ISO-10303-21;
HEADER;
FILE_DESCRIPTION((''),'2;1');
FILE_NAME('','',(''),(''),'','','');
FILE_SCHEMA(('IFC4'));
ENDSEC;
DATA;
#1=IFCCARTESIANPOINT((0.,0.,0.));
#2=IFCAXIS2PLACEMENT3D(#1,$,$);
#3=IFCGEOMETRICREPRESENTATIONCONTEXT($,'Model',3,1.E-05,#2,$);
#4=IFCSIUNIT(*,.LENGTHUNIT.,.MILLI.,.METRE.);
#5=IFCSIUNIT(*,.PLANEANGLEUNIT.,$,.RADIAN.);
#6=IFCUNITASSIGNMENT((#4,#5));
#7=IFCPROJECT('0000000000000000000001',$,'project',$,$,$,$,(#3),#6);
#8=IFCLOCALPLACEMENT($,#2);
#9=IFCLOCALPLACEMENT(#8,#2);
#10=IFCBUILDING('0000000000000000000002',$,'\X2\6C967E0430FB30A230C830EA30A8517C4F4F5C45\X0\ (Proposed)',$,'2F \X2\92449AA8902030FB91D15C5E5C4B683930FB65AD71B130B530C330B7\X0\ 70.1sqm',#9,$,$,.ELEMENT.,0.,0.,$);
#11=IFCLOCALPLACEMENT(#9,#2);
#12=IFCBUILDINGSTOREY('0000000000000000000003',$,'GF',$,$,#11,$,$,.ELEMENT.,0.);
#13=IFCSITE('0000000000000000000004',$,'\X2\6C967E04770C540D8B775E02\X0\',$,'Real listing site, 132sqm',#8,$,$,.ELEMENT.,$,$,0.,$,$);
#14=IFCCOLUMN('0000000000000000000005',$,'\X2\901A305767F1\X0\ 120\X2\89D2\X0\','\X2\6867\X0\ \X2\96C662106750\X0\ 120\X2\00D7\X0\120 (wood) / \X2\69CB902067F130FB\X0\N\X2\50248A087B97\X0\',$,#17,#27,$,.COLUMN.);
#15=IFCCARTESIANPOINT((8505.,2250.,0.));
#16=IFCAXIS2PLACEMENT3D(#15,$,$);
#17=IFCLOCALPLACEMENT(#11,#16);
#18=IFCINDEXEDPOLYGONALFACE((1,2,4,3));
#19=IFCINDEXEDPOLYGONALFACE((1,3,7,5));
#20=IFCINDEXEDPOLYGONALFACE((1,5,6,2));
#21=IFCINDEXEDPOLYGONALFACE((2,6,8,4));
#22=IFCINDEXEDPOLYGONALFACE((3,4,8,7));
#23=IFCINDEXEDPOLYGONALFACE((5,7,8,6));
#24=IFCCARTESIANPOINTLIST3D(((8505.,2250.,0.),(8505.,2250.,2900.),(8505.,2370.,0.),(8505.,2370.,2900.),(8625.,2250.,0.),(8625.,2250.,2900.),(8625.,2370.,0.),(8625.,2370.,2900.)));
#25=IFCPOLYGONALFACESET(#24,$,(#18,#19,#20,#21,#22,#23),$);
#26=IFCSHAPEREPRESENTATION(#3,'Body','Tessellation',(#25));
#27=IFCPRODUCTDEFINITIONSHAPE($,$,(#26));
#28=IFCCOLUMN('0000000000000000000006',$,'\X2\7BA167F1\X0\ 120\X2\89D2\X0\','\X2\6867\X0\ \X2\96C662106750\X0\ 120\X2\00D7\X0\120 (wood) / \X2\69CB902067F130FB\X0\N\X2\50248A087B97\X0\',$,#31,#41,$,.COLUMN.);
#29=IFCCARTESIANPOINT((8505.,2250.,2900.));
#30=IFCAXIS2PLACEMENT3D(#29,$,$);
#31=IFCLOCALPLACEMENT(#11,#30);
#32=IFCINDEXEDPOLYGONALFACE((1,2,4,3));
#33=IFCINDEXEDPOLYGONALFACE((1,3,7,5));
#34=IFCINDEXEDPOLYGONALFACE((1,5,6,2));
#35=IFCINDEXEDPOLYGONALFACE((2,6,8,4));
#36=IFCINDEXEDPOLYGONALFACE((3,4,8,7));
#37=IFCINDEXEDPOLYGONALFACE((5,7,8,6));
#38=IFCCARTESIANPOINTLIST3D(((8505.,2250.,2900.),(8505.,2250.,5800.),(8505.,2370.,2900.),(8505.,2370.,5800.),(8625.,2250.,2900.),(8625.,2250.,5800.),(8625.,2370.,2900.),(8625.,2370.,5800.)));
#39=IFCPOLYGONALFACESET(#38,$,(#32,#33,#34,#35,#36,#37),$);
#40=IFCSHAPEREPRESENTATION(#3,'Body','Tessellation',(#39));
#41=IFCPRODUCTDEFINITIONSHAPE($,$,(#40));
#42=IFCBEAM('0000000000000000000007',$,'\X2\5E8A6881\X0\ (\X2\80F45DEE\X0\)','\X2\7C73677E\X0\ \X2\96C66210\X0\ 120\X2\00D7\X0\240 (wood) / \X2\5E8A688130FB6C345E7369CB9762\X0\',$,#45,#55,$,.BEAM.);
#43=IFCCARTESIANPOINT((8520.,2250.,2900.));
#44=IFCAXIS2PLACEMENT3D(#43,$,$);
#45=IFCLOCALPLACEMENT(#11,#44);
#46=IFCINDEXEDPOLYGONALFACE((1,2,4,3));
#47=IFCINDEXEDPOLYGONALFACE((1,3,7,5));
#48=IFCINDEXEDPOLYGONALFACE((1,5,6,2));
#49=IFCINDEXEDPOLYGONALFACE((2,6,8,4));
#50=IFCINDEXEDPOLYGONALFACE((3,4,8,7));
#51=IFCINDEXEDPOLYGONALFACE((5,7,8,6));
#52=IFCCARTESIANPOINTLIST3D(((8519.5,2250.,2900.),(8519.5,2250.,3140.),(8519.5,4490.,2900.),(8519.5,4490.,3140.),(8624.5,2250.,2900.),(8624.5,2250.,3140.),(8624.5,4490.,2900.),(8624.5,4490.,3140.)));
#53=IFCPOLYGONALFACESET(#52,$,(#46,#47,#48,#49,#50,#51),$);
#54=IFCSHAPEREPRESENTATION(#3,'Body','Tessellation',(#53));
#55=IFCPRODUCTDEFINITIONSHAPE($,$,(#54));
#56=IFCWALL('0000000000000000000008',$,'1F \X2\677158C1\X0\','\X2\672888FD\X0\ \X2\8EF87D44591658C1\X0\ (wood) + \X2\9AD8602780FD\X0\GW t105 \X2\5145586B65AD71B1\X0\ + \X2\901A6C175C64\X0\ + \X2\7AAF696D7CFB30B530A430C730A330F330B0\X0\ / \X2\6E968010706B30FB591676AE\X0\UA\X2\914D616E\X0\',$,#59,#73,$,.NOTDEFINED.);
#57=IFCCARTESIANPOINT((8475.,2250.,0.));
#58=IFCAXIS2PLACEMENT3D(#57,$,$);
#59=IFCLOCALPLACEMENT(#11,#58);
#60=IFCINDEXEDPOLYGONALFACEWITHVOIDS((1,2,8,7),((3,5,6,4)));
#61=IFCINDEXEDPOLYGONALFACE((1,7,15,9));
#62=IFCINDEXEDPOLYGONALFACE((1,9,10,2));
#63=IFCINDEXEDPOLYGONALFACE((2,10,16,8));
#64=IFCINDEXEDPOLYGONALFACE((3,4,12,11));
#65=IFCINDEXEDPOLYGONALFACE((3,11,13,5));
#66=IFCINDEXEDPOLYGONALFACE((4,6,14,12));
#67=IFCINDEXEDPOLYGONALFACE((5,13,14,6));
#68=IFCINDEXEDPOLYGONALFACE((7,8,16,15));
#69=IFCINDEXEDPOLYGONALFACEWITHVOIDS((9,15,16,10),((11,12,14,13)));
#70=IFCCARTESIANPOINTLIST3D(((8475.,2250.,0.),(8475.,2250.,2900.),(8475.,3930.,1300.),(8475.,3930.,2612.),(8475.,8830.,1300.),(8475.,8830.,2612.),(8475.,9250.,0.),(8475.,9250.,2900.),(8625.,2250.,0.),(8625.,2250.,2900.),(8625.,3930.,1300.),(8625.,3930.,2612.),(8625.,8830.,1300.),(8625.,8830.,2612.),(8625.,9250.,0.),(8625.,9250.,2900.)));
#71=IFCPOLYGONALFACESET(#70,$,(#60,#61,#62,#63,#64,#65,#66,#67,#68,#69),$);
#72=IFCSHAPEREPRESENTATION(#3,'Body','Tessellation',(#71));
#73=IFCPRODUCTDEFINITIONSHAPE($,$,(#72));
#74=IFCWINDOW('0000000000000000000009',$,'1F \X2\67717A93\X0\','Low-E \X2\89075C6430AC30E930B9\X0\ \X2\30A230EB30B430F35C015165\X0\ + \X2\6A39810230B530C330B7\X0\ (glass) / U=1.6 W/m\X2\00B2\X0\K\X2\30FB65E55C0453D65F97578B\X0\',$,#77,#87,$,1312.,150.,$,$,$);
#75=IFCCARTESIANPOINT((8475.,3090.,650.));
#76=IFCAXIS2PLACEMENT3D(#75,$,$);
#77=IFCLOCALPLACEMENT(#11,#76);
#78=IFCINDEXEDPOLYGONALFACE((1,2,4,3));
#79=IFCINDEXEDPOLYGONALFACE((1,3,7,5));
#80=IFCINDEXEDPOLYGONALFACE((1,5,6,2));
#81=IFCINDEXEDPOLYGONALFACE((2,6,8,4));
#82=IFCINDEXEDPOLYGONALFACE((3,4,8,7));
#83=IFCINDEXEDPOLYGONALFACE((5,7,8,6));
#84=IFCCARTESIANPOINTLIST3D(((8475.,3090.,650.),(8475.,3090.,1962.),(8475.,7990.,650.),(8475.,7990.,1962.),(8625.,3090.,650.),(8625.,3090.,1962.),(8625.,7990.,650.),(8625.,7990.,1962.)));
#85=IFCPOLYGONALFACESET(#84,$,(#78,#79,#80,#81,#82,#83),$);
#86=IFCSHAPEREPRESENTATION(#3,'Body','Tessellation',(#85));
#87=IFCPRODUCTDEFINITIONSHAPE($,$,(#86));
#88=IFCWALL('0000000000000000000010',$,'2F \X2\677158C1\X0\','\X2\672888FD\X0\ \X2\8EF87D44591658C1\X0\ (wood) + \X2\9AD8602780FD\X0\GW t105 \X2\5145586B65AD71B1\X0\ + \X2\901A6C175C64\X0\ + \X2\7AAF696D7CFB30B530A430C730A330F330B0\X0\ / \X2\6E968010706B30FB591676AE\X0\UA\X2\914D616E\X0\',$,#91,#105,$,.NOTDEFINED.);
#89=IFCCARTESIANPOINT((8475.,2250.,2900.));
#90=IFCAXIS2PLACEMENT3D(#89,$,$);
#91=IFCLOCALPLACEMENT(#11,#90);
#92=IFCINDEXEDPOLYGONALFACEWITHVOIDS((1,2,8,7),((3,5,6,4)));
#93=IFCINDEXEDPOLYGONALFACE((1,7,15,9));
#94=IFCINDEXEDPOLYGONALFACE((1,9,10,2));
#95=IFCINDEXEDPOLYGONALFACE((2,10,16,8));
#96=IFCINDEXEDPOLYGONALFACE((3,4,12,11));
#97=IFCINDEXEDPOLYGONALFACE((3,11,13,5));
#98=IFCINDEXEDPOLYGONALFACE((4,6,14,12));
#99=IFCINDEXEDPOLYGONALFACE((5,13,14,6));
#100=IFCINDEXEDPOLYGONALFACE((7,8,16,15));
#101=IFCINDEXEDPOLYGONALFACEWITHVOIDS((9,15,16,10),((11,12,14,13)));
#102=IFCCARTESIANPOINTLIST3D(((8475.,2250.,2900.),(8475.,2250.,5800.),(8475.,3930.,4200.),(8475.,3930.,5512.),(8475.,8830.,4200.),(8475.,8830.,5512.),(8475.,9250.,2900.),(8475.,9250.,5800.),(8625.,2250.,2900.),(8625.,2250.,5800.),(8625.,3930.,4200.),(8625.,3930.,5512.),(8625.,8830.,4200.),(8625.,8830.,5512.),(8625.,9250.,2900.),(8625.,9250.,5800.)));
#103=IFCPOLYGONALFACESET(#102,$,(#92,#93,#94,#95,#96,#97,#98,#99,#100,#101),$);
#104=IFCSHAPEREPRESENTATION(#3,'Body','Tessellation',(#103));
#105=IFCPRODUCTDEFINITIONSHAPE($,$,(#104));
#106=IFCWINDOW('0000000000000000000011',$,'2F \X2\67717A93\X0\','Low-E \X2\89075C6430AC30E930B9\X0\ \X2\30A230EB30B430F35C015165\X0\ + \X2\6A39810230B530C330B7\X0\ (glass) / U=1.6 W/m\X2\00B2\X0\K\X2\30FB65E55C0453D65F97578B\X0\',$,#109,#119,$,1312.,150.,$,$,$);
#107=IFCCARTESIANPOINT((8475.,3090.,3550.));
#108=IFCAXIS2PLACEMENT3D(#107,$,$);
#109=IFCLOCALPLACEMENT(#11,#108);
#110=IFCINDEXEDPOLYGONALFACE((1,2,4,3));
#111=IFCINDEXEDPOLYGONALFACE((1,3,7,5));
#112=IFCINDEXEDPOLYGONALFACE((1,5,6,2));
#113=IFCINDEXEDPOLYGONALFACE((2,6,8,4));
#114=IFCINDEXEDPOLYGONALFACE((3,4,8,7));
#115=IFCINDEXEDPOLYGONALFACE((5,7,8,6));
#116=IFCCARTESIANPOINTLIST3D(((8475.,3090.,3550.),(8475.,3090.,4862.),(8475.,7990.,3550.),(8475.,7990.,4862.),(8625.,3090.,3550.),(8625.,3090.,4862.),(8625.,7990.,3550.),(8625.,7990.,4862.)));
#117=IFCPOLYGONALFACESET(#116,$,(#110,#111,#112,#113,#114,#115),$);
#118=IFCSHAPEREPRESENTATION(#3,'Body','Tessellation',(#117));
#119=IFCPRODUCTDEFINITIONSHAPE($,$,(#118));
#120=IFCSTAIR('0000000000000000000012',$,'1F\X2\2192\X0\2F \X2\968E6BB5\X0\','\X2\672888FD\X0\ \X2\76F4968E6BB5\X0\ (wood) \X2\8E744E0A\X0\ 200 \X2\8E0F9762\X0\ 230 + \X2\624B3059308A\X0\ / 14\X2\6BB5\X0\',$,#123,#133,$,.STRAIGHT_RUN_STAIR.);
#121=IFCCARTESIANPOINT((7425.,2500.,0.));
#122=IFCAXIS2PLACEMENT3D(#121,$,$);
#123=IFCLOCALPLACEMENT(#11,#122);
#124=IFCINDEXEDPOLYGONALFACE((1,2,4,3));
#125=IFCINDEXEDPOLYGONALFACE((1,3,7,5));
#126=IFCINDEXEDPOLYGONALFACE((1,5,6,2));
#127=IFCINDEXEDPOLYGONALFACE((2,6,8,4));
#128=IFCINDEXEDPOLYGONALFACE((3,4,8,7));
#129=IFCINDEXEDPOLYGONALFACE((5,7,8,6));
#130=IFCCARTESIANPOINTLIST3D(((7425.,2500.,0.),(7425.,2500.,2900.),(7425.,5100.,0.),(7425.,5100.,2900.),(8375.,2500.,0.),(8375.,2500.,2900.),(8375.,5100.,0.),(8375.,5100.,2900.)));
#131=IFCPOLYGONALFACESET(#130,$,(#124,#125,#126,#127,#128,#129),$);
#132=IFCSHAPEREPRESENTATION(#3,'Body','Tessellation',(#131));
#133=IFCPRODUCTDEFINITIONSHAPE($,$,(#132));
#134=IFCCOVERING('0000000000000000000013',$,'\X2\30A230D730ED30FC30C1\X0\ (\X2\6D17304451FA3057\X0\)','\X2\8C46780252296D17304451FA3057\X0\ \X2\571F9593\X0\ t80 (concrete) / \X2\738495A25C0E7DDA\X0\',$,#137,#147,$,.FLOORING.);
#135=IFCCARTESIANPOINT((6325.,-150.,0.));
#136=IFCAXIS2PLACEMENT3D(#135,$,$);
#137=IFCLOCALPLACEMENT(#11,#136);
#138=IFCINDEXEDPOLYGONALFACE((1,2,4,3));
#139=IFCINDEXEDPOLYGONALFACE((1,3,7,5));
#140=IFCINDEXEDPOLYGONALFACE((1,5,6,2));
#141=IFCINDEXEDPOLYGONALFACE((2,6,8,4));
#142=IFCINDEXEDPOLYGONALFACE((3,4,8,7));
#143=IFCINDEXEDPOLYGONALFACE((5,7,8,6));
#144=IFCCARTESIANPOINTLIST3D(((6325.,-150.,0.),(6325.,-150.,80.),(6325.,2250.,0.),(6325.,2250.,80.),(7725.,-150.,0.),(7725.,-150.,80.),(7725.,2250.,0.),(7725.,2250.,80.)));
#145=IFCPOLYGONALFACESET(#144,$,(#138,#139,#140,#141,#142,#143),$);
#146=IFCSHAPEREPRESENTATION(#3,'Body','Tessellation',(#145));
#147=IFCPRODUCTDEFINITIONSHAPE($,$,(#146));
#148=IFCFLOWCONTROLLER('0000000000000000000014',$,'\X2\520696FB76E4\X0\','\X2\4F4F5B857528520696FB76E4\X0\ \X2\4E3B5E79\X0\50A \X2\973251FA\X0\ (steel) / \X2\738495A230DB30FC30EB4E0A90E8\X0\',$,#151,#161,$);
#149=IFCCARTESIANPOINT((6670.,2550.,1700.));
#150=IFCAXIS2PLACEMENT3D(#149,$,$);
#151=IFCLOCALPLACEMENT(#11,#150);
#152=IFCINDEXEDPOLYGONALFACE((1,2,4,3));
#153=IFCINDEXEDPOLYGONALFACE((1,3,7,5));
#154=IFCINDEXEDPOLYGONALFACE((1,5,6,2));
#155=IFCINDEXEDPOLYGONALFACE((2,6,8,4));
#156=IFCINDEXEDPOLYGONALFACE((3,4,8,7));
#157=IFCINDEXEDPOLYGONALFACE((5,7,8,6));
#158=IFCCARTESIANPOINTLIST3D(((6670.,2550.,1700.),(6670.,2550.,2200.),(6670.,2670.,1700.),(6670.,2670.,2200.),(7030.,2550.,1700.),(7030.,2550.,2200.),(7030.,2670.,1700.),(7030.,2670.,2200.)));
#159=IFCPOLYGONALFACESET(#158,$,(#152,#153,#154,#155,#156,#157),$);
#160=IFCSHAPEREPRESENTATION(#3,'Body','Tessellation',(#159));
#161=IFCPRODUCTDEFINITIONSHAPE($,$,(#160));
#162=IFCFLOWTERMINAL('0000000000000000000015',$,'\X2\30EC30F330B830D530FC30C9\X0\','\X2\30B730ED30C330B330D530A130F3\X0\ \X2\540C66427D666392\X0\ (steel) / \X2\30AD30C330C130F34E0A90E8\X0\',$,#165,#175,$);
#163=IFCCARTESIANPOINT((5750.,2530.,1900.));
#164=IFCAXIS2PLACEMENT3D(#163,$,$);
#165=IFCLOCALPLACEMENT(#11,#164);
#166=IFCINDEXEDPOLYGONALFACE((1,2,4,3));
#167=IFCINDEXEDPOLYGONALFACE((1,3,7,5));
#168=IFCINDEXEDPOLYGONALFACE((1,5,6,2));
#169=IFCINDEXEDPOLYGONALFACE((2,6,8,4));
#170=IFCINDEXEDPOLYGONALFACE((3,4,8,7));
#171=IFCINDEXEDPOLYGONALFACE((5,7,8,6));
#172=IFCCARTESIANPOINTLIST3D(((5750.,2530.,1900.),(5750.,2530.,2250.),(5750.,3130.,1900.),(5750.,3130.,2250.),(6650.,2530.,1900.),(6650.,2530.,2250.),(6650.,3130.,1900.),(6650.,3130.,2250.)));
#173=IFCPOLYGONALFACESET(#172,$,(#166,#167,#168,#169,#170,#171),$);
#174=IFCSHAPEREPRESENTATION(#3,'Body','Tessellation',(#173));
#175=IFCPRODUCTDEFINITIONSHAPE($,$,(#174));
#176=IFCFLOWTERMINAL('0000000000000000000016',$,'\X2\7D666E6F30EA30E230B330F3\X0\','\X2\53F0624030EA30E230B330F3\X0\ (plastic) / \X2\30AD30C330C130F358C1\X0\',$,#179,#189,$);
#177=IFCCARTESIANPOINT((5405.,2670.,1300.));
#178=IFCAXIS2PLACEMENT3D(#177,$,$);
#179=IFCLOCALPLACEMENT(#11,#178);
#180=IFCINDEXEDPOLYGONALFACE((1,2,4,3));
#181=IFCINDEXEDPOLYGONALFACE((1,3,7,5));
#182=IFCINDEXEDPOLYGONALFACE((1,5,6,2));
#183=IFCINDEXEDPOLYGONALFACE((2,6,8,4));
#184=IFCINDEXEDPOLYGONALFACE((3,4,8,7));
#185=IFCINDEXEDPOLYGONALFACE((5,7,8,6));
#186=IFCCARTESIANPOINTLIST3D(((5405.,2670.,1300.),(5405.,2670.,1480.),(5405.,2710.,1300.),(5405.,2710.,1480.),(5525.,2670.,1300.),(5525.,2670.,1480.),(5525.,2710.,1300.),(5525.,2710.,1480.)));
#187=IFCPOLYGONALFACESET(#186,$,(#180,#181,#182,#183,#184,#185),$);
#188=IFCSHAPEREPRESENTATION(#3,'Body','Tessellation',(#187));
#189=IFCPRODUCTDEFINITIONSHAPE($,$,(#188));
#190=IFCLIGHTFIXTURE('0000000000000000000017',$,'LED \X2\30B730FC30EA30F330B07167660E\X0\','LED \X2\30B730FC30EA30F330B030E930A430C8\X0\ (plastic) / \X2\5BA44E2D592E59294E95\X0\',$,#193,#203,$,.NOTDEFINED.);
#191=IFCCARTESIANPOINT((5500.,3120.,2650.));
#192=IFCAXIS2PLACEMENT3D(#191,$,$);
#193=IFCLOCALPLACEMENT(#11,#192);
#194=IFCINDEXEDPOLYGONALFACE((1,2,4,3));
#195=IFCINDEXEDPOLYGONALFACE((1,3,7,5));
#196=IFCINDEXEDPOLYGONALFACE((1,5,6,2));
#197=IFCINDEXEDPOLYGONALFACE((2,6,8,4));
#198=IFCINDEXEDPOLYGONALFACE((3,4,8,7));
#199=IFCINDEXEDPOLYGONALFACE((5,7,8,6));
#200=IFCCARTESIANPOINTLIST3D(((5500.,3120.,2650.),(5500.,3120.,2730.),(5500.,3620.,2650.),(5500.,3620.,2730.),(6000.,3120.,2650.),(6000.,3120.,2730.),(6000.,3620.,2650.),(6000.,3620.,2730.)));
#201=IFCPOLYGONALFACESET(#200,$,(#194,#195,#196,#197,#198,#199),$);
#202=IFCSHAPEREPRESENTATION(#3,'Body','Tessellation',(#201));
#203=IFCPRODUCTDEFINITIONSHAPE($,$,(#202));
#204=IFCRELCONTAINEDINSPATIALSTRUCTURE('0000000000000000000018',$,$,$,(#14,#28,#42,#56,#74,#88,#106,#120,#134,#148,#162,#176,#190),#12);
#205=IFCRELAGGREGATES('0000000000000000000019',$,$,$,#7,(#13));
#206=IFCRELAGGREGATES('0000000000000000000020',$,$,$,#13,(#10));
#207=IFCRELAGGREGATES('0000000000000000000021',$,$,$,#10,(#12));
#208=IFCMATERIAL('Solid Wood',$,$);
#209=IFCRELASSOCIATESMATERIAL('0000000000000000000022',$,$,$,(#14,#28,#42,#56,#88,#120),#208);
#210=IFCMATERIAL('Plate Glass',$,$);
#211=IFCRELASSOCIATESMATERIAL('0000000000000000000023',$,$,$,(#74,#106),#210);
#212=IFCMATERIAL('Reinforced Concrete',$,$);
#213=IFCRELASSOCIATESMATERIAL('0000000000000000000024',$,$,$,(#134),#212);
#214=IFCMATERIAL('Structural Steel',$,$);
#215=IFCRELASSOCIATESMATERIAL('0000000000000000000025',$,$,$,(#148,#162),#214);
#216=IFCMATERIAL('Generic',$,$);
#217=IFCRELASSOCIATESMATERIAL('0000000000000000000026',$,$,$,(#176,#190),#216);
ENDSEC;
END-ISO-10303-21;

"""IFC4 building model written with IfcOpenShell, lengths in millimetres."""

from ifc_helpers import new_model, si_unit, frame, frame_2d, origin, place, context, project, spatial, rectangle, extrude, material, element, fill, save


model = new_model("IFC4")

# Units and contexts
model_context = context("Model", 3, precision=1e-05, world=origin())
ifc_project = project(units=[si_unit("LENGTHUNIT", "METRE", prefix="MILLI"), si_unit("PLANEANGLEUNIT", "RADIAN")], contexts=[model_context])

# Site, building, storey
site_placement = place(None, origin())
site = spatial("IfcSite", under=ifc_project, at=site_placement, Name="沖縄県名護市", ObjectType="Real listing site, 132sqm", CompositionType="ELEMENT", RefElevation=0.0)
building_placement = place(site_placement, origin())
building = spatial("IfcBuilding", under=site, at=building_placement, Name="沖縄・アトリエ兼住居 (Proposed)", ObjectType="2F 鉄骨造・金属屋根・断熱サッシ 70.1sqm", CompositionType="ELEMENT", ElevationOfRefHeight=0.0, ElevationOfTerrain=0.0)
storey_placement = place(building_placement, origin())
storey = spatial("IfcBuildingStorey", under=building, at=storey_placement, Name="GF", CompositionType="ELEMENT", Elevation=0.0)

# Columns
ifc_material_1 = material(Name="Solid Wood")
column_1_placement = place(storey_placement, frame((8505.0, 2250.0, 0.0)))
element("IfcColumn", 1, at=column_1_placement, inside=storey, material=ifc_material_1, Name="通し柱 120角", Description="桧 集成材 120×120 (wood) / 構造柱・N値計算", PredefinedType="COLUMN", context=model_context, shape_type="SweptSolid", body=[
    extrude(rectangle(XDim=120.0, YDim=120.0, at=frame_2d((60.0, 60.0))), frame((8505.0, 2250.0, 0.0)), (0.0, 0.0, 1.0), 2900.0),
])
column_2_placement = place(storey_placement, frame((8505.0, 2250.0, 2900.0)))
element("IfcColumn", 2, at=column_2_placement, inside=storey, material=ifc_material_1, Name="管柱 120角", Description="桧 集成材 120×120 (wood) / 構造柱・N値計算", PredefinedType="COLUMN", context=model_context, shape_type="SweptSolid", body=[
    extrude(rectangle(XDim=120.0, YDim=120.0, at=frame_2d((60.0, 60.0))), frame((8505.0, 2250.0, 2900.0)), (0.0, 0.0, 1.0), 2900.0),
])

# Beam
beam_1_placement = place(storey_placement, frame((8520.0, 2250.0, 2900.0)))
element("IfcBeam", 3, at=beam_1_placement, inside=storey, material=ifc_material_1, Name="床梁 (胴差)", Description="米松 集成 120×240 (wood) / 床梁・水平構面", PredefinedType="BEAM", context=model_context, shape_type="SweptSolid", body=[
    extrude(rectangle(XDim=105.0, YDim=2240.0, at=frame_2d((52.0, 1120.0))), frame((8520.0, 2250.0, 2900.0)), (0.0, 0.0, 1.0), 240.0),
])

# Wall, opening, window
wall_1_placement = place(storey_placement, frame((8475.0, 2250.0, 0.0)))
wall_1 = element("IfcWall", 4, at=wall_1_placement, inside=storey, material=ifc_material_1, Name="1F 東壁", Description="木製 軸組外壁 (wood) + 高性能GW t105 充填断熱 + 通気層 + 窯業系サイディング / 準耐火・外皮UA配慮", PredefinedType="NOTDEFINED", context=model_context, shape_type="SweptSolid", body=[
    extrude(rectangle(XDim=150.0, YDim=7000.0, at=frame_2d((75.0, 3500.0))), frame((8475.0, 2250.0, 0.0)), (0.0, 0.0, 1.0), 2900.0),
])
opening_1_placement = place(storey_placement, frame((8475.0, 3090.0, 650.0)))
opening_1 = element("IfcOpeningElement", 5, at=opening_1_placement, cuts=wall_1, PredefinedType="NOTDEFINED", context=model_context, shape_type="SweptSolid", body=[
    extrude(rectangle(XDim=150.0, YDim=4900.0, at=frame_2d((75.0, 2450.0))), frame((8475.0, 3090.0, 650.0)), (0.0, 0.0, 1.0), 1312.0),
])
ifc_material_2 = material(Name="Plate Glass")
window_1_placement = place(storey_placement, frame((8475.0, 3090.0, 650.0)))
window_1 = element("IfcWindow", 6, at=window_1_placement, inside=storey, material=ifc_material_2, Name="1F 東窓", Description="Low-E 複層ガラス アルゴン封入 + 樹脂サッシ (glass) / U=1.6 W/m²K・日射取得型", OverallHeight=1312.0, OverallWidth=150.0, context=model_context, shape_type="SweptSolid", body=[
    extrude(rectangle(XDim=150.0, YDim=4900.0, at=frame_2d((75.0, 2450.0))), frame((8475.0, 3090.0, 650.0)), (0.0, 0.0, 1.0), 1312.0),
])
fill(opening_1, window_1)

# Wall, opening, window
wall_2_placement = place(storey_placement, frame((8475.0, 2250.0, 2900.0)))
wall_2 = element("IfcWall", 7, at=wall_2_placement, inside=storey, material=ifc_material_1, Name="2F 東壁", Description="木製 軸組外壁 (wood) + 高性能GW t105 充填断熱 + 通気層 + 窯業系サイディング / 準耐火・外皮UA配慮", PredefinedType="NOTDEFINED", context=model_context, shape_type="SweptSolid", body=[
    extrude(rectangle(XDim=150.0, YDim=7000.0, at=frame_2d((75.0, 3500.0))), frame((8475.0, 2250.0, 2900.0)), (0.0, 0.0, 1.0), 2900.0),
])
opening_2_placement = place(storey_placement, frame((8475.0, 3090.0, 3550.0)))
opening_2 = element("IfcOpeningElement", 8, at=opening_2_placement, cuts=wall_2, PredefinedType="NOTDEFINED", context=model_context, shape_type="SweptSolid", body=[
    extrude(rectangle(XDim=150.0, YDim=4900.0, at=frame_2d((75.0, 2450.0))), frame((8475.0, 3090.0, 3550.0)), (0.0, 0.0, 1.0), 1312.0),
])
window_2_placement = place(storey_placement, frame((8475.0, 3090.0, 3550.0)))
window_2 = element("IfcWindow", 9, at=window_2_placement, inside=storey, material=ifc_material_2, Name="2F 東窓", Description="Low-E 複層ガラス アルゴン封入 + 樹脂サッシ (glass) / U=1.6 W/m²K・日射取得型", OverallHeight=1312.0, OverallWidth=150.0, context=model_context, shape_type="SweptSolid", body=[
    extrude(rectangle(XDim=150.0, YDim=4900.0, at=frame_2d((75.0, 2450.0))), frame((8475.0, 3090.0, 3550.0)), (0.0, 0.0, 1.0), 1312.0),
])
fill(opening_2, window_2)

# Stair
stair_placement = place(storey_placement, frame((7425.0, 2500.0, 0.0)))
element("IfcStair", 10, at=stair_placement, inside=storey, material=ifc_material_1, Name="1F→2F 階段", Description="木製 直階段 (wood) 蹴上 200 踏面 230 + 手すり / 14段", PredefinedType="STRAIGHT_RUN_STAIR", context=model_context, shape_type="SweptSolid", body=[
    extrude(rectangle(XDim=950.0, YDim=2600.0, at=frame_2d((475.0, 1300.0))), frame((7425.0, 2500.0, 0.0)), (0.0, 0.0, 1.0), 2900.0),
])

# Covering
ifc_material_3 = material(Name="Reinforced Concrete")
covering_placement = place(storey_placement, frame((6325.0, -150.0, 0.0)))
element("IfcCovering", 11, at=covering_placement, inside=storey, material=ifc_material_3, Name="アプローチ (洗い出し)", Description="豆砂利洗い出し 土間 t80 (concrete) / 玄関導線", PredefinedType="FLOORING", context=model_context, shape_type="SweptSolid", body=[
    extrude(rectangle(XDim=1400.0, YDim=2400.0, at=frame_2d((700.0, 1200.0))), frame((6325.0, -150.0, 0.0)), (0.0, 0.0, 1.0), 80.0),
])

# Flow controller
ifc_material_4 = material(Name="Structural Steel")
flow_controller_placement = place(storey_placement, frame((6670.0, 2550.0, 1700.0)))
element("IfcFlowController", 12, at=flow_controller_placement, inside=storey, material=ifc_material_4, Name="分電盤", Description="住宅用分電盤 主幹50A 露出 (steel) / 玄関ホール上部", context=model_context, shape_type="SweptSolid", body=[
    extrude(rectangle(XDim=360.0, YDim=120.0, at=frame_2d((180.0, 60.0))), frame((6670.0, 2550.0, 1700.0)), (0.0, 0.0, 1.0), 500.0),
])

# Flow terminals
flow_terminal_1_placement = place(storey_placement, frame((5750.0, 2530.0, 1900.0)))
element("IfcFlowTerminal", 13, at=flow_terminal_1_placement, inside=storey, material=ifc_material_4, Name="レンジフード", Description="シロッコファン 同時給排 (steel) / キッチン上部", context=model_context, shape_type="SweptSolid", body=[
    extrude(rectangle(XDim=900.0, YDim=600.0, at=frame_2d((450.0, 300.0))), frame((5750.0, 2530.0, 1900.0)), (0.0, 0.0, 1.0), 350.0),
])
ifc_material_5 = material(Name="Generic")
flow_terminal_2_placement = place(storey_placement, frame((5405.0, 2670.0, 1300.0)))
element("IfcFlowTerminal", 14, at=flow_terminal_2_placement, inside=storey, material=ifc_material_5, Name="給湯リモコン", Description="台所リモコン (plastic) / キッチン壁", context=model_context, shape_type="SweptSolid", body=[
    extrude(rectangle(XDim=120.0, YDim=40.0, at=frame_2d((60.0, 20.0))), frame((5405.0, 2670.0, 1300.0)), (0.0, 0.0, 1.0), 180.0),
])

# Light fixture
light_fixture_1_placement = place(storey_placement, frame((5500.0, 3120.0, 2650.0)))
element("IfcLightFixture", 15, at=light_fixture_1_placement, inside=storey, material=ifc_material_5, Name="LED シーリング照明", Description="LED シーリングライト (plastic) / 室中央天井", PredefinedType="NOTDEFINED", context=model_context, shape_type="SweptSolid", body=[
    extrude(rectangle(XDim=500.0, YDim=500.0, at=frame_2d((250.0, 250.0))), frame((5500.0, 3120.0, 2650.0)), (0.0, 0.0, 1.0), 80.0),
])

save(model, "model.ifc")
